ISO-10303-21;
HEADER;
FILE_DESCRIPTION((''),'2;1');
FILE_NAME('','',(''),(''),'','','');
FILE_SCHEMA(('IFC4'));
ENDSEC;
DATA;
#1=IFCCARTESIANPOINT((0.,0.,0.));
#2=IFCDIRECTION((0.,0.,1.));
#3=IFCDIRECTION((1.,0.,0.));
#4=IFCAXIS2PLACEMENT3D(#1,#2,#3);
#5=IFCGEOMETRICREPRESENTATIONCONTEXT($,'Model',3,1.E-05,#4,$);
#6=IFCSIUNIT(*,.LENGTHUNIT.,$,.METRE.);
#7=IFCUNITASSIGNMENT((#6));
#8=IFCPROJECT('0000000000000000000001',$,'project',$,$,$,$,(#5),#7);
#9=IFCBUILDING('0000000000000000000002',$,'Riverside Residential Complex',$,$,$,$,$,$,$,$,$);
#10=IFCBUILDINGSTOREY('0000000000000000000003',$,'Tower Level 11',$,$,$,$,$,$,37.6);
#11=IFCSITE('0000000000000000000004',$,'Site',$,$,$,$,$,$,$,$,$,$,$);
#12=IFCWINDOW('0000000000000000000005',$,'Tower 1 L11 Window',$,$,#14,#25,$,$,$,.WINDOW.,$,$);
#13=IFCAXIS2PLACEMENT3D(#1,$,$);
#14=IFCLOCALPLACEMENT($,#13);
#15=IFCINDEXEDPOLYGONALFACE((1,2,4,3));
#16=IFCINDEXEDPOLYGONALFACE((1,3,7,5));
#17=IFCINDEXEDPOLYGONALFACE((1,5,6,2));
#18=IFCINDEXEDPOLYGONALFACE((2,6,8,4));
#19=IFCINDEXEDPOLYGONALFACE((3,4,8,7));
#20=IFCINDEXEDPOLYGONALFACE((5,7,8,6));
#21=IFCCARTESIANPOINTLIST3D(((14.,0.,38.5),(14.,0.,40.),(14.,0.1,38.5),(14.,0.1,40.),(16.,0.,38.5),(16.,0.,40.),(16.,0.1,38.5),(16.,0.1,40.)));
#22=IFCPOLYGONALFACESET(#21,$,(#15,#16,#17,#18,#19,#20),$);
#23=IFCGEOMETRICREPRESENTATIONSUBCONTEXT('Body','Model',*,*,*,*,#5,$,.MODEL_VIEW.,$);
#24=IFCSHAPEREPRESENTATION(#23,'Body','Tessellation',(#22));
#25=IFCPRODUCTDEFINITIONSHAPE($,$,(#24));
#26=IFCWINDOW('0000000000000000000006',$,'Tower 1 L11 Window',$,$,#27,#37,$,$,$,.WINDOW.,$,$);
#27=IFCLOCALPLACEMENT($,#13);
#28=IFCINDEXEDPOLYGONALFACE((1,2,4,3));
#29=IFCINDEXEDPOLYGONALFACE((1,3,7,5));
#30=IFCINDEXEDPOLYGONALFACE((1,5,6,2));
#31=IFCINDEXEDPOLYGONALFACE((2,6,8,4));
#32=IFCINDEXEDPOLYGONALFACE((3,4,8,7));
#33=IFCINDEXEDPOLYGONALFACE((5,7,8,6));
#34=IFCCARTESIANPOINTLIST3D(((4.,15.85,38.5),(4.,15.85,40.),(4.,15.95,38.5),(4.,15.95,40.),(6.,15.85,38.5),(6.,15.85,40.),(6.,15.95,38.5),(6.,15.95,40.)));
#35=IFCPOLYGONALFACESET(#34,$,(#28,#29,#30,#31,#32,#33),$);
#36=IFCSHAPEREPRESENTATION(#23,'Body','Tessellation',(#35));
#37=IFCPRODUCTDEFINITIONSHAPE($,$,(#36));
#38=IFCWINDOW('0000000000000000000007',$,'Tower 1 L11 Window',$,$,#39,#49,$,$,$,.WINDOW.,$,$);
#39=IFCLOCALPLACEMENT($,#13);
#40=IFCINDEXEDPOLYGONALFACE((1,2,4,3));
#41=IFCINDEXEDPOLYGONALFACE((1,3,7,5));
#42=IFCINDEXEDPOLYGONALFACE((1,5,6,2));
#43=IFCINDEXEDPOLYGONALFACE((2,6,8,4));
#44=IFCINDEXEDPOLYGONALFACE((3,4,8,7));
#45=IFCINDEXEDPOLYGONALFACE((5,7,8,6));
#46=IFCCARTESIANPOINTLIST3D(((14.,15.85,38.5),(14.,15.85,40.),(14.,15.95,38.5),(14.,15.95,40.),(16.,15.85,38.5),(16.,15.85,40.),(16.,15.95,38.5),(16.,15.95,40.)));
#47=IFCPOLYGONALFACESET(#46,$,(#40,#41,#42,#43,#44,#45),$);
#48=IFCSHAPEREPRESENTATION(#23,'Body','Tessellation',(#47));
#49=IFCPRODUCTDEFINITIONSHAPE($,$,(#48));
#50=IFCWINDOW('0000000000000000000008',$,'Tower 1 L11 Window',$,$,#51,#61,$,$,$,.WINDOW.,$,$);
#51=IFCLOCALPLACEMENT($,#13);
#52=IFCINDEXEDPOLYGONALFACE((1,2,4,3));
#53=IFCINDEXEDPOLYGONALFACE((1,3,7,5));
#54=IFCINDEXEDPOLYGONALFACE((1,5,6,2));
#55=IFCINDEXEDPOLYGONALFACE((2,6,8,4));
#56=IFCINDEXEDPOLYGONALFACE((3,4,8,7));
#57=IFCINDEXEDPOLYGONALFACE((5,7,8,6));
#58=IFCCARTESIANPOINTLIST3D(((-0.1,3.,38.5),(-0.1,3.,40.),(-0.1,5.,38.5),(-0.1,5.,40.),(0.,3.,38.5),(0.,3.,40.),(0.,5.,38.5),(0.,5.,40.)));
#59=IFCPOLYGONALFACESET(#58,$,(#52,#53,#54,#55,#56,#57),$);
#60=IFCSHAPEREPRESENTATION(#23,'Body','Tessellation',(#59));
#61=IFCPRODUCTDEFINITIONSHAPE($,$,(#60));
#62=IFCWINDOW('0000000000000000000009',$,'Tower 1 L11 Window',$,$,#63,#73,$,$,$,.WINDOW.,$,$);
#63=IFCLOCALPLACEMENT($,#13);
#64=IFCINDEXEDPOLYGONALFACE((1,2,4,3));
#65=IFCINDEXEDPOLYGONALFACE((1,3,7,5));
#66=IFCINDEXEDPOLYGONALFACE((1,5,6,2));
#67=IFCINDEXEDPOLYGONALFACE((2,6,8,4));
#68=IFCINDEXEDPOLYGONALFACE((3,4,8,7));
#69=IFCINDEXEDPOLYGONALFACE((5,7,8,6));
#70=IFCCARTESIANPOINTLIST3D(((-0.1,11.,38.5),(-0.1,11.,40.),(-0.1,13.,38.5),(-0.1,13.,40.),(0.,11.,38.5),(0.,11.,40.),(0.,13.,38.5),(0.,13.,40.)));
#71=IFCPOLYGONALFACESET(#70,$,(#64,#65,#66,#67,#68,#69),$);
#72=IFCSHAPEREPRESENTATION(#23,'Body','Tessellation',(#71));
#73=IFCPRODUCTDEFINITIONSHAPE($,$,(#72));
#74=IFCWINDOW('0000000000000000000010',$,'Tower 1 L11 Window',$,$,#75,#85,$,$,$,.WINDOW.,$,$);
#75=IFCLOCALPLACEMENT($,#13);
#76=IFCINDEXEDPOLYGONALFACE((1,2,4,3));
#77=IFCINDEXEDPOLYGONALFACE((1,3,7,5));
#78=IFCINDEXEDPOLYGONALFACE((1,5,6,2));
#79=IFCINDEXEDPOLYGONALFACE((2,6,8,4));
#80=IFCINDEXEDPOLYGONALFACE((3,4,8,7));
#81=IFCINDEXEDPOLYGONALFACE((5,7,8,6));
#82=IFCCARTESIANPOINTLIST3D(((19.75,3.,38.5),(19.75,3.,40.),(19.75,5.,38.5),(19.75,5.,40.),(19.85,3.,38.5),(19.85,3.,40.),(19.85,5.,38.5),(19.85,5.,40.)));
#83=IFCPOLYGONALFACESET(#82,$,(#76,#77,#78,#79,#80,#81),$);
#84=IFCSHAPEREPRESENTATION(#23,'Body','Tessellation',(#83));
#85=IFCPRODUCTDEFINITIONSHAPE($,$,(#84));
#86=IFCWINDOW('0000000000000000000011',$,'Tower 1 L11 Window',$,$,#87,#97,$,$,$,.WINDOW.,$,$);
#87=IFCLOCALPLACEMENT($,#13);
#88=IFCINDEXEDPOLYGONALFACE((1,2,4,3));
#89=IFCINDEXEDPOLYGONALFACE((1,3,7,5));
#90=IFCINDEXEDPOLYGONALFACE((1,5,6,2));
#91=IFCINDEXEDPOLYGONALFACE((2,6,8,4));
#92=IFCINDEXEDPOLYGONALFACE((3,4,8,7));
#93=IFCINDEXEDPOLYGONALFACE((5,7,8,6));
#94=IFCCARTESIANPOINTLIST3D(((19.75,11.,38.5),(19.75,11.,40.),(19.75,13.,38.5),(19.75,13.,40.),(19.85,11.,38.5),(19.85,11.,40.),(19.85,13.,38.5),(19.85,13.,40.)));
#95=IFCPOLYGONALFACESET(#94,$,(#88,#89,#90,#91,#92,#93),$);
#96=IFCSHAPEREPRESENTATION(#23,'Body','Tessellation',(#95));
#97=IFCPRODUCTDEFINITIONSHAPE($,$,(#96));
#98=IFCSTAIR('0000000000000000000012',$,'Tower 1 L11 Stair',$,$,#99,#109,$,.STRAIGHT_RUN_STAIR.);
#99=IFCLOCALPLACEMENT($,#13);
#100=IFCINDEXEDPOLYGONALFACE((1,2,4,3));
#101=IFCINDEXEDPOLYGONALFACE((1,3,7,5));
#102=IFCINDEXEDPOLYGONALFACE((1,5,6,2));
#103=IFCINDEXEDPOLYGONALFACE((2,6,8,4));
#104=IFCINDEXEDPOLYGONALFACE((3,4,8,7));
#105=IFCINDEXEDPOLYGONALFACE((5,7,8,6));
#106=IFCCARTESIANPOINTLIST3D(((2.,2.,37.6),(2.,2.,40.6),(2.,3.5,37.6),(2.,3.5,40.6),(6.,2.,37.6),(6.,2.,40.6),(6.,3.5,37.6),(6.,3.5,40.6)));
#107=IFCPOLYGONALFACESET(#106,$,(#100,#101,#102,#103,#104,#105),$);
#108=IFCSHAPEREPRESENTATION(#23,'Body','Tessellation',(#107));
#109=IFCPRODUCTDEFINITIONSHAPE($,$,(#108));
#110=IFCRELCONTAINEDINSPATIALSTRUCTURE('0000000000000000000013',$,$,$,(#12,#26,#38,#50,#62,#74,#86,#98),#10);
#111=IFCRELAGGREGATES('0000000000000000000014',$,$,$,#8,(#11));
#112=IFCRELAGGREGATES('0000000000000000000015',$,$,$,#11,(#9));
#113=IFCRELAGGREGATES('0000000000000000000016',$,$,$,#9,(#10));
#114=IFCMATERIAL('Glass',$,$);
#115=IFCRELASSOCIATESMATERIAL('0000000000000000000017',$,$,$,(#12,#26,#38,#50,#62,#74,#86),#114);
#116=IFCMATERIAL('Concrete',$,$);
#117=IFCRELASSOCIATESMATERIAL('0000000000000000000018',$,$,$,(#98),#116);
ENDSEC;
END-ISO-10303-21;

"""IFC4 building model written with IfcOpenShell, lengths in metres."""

from ifc_helpers import new_model, si_unit, frame, origin_with_axes, place, context, subcontext, project, spatial, line, indexed_curve, outline, extrude, material, element, save


model = new_model("IFC4")

# Units and contexts
model_context = context("Model", 3, precision=1e-05, world=origin_with_axes())
body_context = subcontext(model_context, "Body", "Model", "MODEL_VIEW")
ifc_project = project(units=[si_unit("LENGTHUNIT", "METRE")], contexts=[model_context])

# Site, building, storey
site = spatial("IfcSite", under=ifc_project, Name="Site")
building = spatial("IfcBuilding", under=site, Name="Riverside Residential Complex")
storey = spatial("IfcBuildingStorey", under=building, Name="Tower Level 11", Elevation=37.6)

# Shared definitions
ifc_material_1 = material(Name="Concrete")

# Windows
ifc_material_2 = material(Name="Glass")
for number, where, z_axis, x_axis, name in (
    (1, (14.0, 0.0, 38.5), (0.0, 0.0, 1.0), (1.0, 0.0, 0.0), "Tower 1 L11 Window"),
    (2, (4.0, 15.85, 38.5), (0.0, 0.0, 1.0), (1.0, 0.0, 0.0), "Tower 1 L11 Window"),
    (3, (14.0, 15.85, 38.5), (0.0, 0.0, 1.0), (1.0, 0.0, 0.0), "Tower 1 L11 Window"),
    (4, (0.0, 3.0, 38.5), (0.0, 0.0, 1.0), (0.0, 1.0, 0.0), "Tower 1 L11 Window"),
    (5, (0.0, 11.0, 38.5), (0.0, 0.0, 1.0), (0.0, 1.0, 0.0), "Tower 1 L11 Window"),
    (6, (19.85, 3.0, 38.5), (0.0, 0.0, 1.0), (0.0, 1.0, 0.0), "Tower 1 L11 Window"),
    (7, (19.85, 11.0, 38.5), (0.0, 0.0, 1.0), (0.0, 1.0, 0.0), "Tower 1 L11 Window"),
):
    element("IfcWindow", number, at=place(None, frame(where, z_axis=z_axis, x_axis=x_axis)), inside=storey, material=ifc_material_2, Name=name, PredefinedType="WINDOW", context=body_context, shape_type="SweptSolid", body=[
        extrude(outline(indexed_curve([(0.0, 0.0), (2.0, 0.0), (2.0, 0.1), (0.0, 0.1)], segments=[line(1, 2, 3, 4, 1)])), origin_with_axes(), (0.0, 0.0, 1.0), 1.5),
    ])

# Stair
stair_placement = place(None, frame((2.0, 2.0, 37.6), z_axis=(0.0, 0.0, 1.0), x_axis=(1.0, 0.0, 0.0)))
element("IfcStair", 8, at=stair_placement, inside=storey, material=ifc_material_1, Name="Tower 1 L11 Stair", PredefinedType="STRAIGHT_RUN_STAIR", context=body_context, shape_type="SweptSolid", body=[
    extrude(outline(indexed_curve([(0.0, 0.0), (4.0, 0.0), (4.0, 1.5), (0.0, 1.5)], segments=[line(1, 2, 3, 4, 1)])), origin_with_axes(), (0.0, 0.0, 1.0), 3.0),
])

save(model, "model.ifc")
